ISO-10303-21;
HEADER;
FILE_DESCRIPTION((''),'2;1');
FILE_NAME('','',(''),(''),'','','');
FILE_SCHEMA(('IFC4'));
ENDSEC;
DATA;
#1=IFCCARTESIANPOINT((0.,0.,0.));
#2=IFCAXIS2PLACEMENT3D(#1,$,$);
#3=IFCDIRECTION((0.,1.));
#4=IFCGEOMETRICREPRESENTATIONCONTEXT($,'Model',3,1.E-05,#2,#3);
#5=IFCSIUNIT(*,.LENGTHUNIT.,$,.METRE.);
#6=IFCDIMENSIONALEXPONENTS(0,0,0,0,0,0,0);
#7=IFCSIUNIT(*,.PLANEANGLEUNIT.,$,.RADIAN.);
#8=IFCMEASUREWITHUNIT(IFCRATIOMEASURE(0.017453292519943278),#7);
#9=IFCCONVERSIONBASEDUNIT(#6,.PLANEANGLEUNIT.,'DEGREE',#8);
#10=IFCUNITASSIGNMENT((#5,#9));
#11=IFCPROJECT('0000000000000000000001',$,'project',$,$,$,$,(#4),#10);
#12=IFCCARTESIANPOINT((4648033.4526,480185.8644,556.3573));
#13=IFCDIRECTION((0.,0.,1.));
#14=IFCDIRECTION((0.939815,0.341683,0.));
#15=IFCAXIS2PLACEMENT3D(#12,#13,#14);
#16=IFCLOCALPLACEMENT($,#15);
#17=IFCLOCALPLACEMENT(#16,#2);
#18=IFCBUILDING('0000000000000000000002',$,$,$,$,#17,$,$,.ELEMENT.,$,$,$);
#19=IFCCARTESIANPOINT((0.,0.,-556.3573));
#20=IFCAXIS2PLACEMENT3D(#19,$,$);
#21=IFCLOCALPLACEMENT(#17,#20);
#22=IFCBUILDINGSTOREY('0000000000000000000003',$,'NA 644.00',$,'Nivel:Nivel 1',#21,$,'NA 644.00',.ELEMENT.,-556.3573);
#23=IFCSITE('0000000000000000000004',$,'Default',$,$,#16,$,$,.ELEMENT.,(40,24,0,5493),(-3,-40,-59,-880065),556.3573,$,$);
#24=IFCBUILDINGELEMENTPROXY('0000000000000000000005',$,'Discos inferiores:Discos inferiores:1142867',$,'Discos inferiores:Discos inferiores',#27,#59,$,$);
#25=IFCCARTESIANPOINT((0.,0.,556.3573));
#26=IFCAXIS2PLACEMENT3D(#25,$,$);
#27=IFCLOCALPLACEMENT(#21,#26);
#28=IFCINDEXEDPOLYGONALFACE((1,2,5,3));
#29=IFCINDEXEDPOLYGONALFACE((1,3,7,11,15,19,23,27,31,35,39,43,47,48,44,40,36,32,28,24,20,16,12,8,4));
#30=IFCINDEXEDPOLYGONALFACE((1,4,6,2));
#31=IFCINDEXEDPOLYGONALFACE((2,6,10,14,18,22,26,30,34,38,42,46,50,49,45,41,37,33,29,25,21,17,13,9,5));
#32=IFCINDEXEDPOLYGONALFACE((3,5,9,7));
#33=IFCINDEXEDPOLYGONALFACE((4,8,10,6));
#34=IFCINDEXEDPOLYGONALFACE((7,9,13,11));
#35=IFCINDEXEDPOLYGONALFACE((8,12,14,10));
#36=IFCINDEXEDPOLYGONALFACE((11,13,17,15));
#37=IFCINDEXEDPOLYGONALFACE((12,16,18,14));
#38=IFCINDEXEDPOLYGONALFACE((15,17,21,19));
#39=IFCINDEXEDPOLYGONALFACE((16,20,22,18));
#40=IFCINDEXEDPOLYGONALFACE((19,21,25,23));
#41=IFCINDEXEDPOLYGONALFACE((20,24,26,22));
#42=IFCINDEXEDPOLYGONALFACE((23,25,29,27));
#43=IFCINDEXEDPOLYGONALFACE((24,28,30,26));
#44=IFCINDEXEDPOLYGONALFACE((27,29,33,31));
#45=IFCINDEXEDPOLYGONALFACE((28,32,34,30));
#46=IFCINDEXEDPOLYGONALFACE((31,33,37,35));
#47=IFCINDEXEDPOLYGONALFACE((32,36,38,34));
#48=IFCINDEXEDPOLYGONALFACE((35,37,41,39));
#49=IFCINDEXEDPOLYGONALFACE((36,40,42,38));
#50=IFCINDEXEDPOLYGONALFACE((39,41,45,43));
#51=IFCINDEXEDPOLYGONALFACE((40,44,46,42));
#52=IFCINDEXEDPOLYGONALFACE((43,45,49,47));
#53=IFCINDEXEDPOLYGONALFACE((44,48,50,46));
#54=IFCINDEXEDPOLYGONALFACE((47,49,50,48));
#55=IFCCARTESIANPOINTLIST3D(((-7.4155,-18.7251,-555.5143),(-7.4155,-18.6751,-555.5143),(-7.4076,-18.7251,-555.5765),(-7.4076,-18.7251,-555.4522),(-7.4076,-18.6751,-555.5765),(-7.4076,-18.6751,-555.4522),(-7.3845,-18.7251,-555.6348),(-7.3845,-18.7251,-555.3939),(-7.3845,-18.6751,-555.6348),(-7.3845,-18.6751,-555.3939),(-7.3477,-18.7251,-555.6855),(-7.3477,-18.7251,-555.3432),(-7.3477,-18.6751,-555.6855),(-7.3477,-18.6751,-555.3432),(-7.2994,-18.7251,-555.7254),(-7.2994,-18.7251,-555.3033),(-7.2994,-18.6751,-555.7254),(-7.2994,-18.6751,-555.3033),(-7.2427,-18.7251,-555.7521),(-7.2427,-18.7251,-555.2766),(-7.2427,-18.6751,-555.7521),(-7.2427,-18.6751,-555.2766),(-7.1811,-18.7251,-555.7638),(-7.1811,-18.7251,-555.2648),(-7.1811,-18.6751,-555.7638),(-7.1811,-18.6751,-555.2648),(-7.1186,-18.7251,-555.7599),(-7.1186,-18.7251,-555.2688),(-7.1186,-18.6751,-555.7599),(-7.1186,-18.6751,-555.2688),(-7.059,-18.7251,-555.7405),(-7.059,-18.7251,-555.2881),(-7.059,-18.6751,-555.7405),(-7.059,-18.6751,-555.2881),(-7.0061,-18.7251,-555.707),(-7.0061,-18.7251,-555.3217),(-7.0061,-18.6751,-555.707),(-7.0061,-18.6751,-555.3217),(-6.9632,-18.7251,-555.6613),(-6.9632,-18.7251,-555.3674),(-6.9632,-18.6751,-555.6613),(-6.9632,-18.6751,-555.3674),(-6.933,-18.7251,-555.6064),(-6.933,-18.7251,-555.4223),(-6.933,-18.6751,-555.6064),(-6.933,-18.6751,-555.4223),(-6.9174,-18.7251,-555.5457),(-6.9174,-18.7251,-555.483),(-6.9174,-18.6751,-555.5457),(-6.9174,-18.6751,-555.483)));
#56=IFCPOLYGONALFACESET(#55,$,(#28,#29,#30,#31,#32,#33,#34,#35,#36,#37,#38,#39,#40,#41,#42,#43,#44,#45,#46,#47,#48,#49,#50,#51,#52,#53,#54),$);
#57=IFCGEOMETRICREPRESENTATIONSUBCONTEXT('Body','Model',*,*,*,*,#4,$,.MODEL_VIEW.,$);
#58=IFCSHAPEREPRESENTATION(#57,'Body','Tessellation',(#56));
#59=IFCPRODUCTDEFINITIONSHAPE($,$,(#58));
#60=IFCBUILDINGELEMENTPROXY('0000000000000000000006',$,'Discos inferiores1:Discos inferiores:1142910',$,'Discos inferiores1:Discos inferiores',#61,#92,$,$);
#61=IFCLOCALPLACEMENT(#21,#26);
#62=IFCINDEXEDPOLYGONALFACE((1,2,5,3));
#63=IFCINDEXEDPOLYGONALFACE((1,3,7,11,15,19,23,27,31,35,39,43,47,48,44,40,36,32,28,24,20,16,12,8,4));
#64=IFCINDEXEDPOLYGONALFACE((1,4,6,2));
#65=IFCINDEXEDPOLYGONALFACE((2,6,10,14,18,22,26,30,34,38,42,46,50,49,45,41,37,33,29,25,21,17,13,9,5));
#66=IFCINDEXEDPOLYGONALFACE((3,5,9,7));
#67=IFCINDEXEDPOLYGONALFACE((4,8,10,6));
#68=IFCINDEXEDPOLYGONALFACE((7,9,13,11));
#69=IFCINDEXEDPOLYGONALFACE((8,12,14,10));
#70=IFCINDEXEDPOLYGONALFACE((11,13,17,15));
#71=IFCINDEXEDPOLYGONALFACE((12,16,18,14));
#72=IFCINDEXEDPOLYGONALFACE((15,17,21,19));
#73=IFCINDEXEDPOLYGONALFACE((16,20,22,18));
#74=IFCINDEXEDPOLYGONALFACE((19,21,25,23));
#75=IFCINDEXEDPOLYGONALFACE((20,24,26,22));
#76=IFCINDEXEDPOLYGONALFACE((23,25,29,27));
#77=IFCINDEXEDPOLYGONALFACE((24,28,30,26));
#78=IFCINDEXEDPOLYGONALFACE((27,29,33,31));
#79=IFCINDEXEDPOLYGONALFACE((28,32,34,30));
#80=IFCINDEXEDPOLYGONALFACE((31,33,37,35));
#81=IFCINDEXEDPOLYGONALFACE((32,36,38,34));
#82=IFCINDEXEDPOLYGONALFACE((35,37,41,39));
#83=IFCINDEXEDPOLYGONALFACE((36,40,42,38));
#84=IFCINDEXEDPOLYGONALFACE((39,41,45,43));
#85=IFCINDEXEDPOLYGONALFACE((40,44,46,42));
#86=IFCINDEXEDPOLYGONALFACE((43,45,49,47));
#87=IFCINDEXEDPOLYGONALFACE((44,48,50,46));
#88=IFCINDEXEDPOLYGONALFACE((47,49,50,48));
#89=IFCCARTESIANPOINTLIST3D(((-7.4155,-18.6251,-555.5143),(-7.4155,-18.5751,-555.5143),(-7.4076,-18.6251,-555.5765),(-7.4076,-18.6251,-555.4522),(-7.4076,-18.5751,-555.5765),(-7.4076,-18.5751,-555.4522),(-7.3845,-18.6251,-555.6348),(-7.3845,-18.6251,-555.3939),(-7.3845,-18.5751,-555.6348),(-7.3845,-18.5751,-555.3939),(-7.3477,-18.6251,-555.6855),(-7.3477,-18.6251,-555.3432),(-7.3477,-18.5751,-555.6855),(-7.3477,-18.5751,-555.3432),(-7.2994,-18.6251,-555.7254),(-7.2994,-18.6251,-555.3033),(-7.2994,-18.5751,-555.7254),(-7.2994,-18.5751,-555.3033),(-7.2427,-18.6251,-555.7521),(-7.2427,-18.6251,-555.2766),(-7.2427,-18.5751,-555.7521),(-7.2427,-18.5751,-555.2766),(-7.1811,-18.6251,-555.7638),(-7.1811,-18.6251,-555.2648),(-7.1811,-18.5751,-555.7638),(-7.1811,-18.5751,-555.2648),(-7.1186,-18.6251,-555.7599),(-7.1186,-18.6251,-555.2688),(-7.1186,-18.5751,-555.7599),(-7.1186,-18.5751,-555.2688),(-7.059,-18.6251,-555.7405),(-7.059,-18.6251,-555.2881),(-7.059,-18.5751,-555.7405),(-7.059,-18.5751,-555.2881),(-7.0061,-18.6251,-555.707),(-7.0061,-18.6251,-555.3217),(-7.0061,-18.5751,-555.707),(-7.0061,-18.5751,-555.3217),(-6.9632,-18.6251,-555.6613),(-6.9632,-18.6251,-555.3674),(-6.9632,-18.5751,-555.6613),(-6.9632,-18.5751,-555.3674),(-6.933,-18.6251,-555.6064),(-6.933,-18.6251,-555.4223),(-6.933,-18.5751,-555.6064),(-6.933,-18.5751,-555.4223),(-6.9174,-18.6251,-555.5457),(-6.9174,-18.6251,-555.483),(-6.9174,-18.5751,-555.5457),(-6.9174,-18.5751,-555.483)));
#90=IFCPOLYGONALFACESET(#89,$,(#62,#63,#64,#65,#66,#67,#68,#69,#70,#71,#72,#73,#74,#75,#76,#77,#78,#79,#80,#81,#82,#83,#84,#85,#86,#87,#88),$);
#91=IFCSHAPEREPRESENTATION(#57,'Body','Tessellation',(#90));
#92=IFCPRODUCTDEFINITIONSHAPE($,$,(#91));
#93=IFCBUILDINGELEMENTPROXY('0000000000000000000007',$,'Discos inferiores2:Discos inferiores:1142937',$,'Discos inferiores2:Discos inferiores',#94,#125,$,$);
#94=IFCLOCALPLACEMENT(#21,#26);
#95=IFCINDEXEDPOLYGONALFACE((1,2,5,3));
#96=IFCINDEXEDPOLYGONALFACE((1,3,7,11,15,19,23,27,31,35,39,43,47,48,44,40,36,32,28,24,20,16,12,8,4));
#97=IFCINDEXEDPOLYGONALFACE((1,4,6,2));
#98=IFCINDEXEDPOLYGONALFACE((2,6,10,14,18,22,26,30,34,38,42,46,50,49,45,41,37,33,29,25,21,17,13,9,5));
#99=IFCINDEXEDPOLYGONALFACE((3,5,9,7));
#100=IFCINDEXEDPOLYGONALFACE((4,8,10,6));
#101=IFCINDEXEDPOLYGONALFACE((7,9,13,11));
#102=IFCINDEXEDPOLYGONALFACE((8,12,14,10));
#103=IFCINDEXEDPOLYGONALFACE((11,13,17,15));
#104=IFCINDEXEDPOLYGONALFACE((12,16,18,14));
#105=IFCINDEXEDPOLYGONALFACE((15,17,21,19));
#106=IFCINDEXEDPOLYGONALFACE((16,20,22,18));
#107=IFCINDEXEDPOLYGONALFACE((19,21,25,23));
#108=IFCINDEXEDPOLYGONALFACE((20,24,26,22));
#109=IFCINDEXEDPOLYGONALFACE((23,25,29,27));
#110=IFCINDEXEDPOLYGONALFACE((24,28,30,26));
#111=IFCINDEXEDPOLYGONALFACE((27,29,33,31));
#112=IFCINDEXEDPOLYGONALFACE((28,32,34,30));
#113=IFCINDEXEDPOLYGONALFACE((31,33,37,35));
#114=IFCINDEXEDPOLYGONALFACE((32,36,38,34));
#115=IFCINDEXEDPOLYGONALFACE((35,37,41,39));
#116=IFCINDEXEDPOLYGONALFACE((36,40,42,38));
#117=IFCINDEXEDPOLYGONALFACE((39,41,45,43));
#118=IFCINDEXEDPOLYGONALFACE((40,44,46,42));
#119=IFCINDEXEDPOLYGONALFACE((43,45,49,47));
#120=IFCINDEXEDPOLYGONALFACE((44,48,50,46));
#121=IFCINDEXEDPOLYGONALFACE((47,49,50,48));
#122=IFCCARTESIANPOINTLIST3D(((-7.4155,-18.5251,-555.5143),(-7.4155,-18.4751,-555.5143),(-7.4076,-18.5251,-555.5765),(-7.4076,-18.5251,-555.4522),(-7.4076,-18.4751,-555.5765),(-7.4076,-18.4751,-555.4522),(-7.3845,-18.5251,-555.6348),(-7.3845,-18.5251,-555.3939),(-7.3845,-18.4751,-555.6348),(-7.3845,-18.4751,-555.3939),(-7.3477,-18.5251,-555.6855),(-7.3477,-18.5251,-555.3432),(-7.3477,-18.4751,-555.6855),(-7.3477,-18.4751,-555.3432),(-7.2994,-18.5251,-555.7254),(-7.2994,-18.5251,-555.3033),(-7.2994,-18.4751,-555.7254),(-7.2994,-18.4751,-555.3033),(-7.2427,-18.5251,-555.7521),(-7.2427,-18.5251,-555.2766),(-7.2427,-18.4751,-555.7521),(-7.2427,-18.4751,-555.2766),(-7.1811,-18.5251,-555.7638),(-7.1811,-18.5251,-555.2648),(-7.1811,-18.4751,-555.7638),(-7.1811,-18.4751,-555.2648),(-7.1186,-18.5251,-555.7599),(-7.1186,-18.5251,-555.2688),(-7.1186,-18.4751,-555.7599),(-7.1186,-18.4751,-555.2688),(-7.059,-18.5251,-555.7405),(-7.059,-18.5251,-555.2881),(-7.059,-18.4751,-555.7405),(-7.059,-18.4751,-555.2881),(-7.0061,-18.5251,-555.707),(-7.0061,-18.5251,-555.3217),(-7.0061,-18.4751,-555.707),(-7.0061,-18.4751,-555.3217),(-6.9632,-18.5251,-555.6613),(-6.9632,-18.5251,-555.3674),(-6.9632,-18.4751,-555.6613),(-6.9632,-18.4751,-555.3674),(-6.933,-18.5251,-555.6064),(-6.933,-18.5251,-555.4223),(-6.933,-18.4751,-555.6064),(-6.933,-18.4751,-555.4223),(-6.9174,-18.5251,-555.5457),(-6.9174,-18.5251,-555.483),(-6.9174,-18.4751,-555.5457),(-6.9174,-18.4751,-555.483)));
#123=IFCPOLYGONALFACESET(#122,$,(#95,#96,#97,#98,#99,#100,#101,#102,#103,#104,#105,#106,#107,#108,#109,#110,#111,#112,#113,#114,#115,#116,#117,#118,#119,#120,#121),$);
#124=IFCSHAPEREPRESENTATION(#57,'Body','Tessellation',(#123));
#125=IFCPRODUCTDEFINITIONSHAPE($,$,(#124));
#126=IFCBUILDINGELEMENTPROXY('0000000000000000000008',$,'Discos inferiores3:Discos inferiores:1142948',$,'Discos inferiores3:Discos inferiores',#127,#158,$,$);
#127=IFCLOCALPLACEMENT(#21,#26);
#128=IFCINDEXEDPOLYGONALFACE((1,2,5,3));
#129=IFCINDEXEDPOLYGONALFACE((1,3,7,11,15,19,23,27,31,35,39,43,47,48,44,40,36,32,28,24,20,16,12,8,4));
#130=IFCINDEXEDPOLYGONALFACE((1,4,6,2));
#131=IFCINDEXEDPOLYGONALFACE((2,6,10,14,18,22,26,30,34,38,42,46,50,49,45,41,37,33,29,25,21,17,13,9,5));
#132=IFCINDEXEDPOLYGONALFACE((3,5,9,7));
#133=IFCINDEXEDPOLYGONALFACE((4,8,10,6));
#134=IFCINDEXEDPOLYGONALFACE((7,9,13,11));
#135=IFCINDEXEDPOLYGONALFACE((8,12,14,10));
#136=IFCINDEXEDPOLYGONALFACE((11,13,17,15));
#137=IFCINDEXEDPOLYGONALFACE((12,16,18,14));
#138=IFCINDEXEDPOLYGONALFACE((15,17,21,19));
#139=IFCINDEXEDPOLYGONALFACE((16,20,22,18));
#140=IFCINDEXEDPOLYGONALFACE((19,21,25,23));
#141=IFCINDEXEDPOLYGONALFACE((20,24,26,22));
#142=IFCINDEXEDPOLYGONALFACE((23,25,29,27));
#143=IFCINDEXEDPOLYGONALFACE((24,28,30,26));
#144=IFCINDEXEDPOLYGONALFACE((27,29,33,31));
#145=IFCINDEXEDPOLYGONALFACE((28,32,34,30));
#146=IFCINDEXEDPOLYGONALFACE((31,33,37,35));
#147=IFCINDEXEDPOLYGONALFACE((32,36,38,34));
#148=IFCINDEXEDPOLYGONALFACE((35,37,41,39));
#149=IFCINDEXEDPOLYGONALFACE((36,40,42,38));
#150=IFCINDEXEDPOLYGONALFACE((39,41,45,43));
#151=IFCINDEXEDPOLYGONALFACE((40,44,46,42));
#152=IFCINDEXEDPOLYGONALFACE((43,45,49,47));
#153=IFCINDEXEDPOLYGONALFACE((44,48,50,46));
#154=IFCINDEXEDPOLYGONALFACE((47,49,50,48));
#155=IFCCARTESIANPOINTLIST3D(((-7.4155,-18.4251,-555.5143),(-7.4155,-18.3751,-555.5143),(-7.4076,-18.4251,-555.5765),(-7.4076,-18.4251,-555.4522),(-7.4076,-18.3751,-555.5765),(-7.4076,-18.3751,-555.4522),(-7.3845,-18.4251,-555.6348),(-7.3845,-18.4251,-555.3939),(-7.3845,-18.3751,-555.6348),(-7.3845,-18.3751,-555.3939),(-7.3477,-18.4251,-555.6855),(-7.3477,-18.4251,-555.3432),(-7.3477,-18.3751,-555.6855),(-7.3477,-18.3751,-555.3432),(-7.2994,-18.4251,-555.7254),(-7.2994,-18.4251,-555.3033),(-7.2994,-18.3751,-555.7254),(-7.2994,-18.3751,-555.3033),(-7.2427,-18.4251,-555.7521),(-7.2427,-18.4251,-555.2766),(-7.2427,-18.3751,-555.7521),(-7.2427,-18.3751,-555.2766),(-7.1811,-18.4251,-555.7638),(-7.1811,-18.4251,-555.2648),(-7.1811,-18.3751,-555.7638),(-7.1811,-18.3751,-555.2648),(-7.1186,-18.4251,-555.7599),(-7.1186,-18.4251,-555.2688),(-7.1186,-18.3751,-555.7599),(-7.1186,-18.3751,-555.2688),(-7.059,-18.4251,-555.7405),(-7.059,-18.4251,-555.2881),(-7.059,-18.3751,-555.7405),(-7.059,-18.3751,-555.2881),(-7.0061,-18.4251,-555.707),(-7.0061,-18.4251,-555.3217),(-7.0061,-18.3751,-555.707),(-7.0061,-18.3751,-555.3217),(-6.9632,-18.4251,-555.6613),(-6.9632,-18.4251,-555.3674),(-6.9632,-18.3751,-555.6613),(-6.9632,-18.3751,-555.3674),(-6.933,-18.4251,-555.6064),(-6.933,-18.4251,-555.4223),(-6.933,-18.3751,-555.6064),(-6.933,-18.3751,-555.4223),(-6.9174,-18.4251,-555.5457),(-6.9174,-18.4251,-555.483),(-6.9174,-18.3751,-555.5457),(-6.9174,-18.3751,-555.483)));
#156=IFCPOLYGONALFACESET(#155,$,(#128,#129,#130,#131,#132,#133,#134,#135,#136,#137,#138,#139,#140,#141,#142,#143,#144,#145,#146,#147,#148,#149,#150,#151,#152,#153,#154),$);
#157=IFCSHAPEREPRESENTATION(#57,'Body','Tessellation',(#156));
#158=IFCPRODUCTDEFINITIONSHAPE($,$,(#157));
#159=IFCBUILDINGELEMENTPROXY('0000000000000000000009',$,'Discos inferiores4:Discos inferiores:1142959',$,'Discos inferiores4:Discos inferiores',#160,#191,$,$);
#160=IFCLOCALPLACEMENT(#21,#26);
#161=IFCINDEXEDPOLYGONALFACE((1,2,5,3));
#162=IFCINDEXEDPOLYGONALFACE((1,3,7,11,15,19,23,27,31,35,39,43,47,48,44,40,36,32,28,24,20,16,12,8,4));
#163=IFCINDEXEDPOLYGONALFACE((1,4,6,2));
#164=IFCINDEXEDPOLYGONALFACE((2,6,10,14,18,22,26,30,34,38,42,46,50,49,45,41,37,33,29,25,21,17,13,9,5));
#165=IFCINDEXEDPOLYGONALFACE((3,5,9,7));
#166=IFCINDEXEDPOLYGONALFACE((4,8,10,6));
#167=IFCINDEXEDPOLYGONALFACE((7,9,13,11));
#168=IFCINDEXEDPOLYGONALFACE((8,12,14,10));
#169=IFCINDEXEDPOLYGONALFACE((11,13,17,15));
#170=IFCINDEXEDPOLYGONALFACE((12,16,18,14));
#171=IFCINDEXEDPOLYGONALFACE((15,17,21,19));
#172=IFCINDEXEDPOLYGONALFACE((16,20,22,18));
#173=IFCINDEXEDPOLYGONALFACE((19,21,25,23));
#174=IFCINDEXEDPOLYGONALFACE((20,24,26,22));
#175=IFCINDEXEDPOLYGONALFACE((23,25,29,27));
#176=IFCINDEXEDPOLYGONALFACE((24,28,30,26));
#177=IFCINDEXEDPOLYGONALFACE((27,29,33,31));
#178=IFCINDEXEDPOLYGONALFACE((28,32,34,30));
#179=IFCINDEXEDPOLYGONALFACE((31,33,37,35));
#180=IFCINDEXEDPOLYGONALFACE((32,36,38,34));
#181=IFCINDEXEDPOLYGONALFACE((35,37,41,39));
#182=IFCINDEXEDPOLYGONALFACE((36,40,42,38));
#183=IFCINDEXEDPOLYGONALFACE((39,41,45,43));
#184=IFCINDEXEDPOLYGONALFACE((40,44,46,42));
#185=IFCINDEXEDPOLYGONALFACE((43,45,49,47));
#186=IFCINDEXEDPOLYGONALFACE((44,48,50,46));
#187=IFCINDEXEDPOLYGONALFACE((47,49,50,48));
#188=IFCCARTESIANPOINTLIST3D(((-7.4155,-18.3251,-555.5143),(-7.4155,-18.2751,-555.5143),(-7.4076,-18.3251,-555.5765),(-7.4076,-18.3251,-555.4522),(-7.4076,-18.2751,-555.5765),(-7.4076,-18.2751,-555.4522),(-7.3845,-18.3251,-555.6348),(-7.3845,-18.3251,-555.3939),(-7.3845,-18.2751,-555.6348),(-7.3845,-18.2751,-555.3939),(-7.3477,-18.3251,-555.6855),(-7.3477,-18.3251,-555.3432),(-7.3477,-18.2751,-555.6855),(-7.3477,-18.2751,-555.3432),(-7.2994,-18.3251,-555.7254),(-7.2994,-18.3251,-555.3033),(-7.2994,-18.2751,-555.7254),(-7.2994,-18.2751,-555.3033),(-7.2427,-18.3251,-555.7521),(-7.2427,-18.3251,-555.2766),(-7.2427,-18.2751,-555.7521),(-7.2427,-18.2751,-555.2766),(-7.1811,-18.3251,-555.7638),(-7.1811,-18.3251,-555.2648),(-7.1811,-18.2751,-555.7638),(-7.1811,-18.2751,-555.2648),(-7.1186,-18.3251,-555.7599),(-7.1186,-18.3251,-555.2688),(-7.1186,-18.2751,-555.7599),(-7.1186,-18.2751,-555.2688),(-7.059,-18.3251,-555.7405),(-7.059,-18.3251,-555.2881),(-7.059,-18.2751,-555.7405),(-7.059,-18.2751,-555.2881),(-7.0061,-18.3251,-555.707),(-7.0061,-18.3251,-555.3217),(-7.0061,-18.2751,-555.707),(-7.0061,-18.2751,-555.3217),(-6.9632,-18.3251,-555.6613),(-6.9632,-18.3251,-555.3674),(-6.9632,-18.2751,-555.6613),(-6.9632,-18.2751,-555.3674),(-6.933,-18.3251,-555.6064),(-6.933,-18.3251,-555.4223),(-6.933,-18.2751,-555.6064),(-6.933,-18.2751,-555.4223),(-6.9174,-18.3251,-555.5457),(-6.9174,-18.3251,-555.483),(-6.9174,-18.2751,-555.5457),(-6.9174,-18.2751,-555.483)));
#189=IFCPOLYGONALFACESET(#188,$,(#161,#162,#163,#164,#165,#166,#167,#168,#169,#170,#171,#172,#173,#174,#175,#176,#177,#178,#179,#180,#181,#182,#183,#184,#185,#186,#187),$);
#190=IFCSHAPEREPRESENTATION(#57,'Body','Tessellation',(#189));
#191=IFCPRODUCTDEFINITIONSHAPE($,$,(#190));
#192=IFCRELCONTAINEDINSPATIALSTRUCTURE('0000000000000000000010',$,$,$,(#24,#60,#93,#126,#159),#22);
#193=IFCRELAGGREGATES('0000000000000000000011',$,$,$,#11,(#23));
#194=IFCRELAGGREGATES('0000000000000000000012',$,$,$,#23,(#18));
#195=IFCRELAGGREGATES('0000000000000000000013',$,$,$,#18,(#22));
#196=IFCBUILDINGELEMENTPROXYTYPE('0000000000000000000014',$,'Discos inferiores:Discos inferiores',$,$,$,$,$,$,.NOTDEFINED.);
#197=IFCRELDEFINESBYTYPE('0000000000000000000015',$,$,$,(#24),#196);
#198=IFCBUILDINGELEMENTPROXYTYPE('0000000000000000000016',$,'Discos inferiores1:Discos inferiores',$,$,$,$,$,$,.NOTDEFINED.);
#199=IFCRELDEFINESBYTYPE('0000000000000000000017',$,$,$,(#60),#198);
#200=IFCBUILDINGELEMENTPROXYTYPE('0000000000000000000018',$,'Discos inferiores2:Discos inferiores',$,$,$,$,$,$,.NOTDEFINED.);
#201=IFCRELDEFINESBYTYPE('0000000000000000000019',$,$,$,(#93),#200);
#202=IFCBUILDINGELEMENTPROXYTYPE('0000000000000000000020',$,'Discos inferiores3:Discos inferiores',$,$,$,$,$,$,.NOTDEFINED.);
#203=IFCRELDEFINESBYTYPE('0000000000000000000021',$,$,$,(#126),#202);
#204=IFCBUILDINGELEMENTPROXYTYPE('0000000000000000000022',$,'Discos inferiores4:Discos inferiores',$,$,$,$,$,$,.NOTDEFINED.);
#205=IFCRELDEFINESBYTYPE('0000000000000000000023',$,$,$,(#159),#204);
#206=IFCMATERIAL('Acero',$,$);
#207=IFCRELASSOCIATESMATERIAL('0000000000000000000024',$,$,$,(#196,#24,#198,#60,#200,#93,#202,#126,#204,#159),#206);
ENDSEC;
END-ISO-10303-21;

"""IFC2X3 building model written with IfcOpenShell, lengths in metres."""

from ifc_helpers import new_model, entity, si_unit, converted_unit, direction, frame, origin, origin_2d_with_axis, place, context, subcontext, project, spatial, circle, extrude, source, transform, mapped, material, type_object, type_shapes, element, save


model = new_model("IFC2X3")

# Units and contexts
model_context = context("Model", 3, precision=1e-05, world=origin(), true_north=direction((0.0, 1.0)))
body_context = subcontext(model_context, "Body", "Model", "MODEL_VIEW")
ifc_project = project(units=[si_unit("LENGTHUNIT", "METRE"), converted_unit("PLANEANGLEUNIT", "DEGREE", entity("IfcRatioMeasure", 0.017453292519943278), si_unit("PLANEANGLEUNIT", "RADIAN"), dimensions=[0, 0, 0, 0, 0, 0, 0])], contexts=[model_context])

# Site, building, storey
site_placement = place(None, frame((4648033.4526, 480185.8644, 556.3573), z_axis=(0.0, 0.0, 1.0), x_axis=(0.939815, 0.341683, 0.0)))
site = spatial("IfcSite", under=ifc_project, at=site_placement, Name="Default", CompositionType="ELEMENT", RefLatitude=(40, 24, 0, 5493), RefLongitude=(-3, -40, -59, -880065), RefElevation=556.3573)
building_placement = place(site_placement, origin())
building = spatial("IfcBuilding", under=site, at=building_placement, CompositionType="ELEMENT")
storey_placement = place(building_placement, frame((0.0, 0.0, -556.3573)))
storey = spatial("IfcBuildingStorey", under=building, at=storey_placement, Name="NA 644.00", ObjectType="Nivel:Nivel 1", LongName="NA 644.00", CompositionType="ELEMENT", Elevation=-556.3573)

# Building element proxies
ifc_material_1 = material(Name="Acero")
building_element_proxy_type_1 = type_object("IfcBuildingElementProxyType", Name="Discos inferiores:Discos inferiores", PredefinedType="NOTDEFINED", material=ifc_material_1)
shared_shape_1 = source(origin(), body_context, "Body", "SweptSolid", [
    extrude(circle(Radius=0.25, at=origin_2d_with_axis()), frame((-7.1655, -18.7251, -555.5143), z_axis=(0.0, 1.0, 0.0), x_axis=(-1.0, 0.0, 0.0)), (0.0, 0.0, 1.0), 0.05),
])
type_shapes(building_element_proxy_type_1, [shared_shape_1])
proxy_1_placement = place(storey_placement, frame((0.0, 0.0, 556.3573)))
element("IfcBuildingElementProxy", 1, at=proxy_1_placement, inside=storey, type_object=building_element_proxy_type_1, material=ifc_material_1, Name="Discos inferiores:Discos inferiores:1142867", ObjectType="Discos inferiores:Discos inferiores", context=body_context, shape_type="MappedRepresentation", body=[
    mapped(shared_shape_1, transform((0.0, 0.0, 0.0), scale=1.0)),
])
building_element_proxy_type_2 = type_object("IfcBuildingElementProxyType", Name="Discos inferiores1:Discos inferiores", PredefinedType="NOTDEFINED", material=ifc_material_1)
shared_shape_2 = source(origin(), body_context, "Body", "SweptSolid", [
    extrude(circle(Radius=0.25, at=origin_2d_with_axis()), frame((-7.1655, -18.6251, -555.5143), z_axis=(0.0, 1.0, 0.0), x_axis=(-1.0, 0.0, 0.0)), (0.0, 0.0, 1.0), 0.05),
])
type_shapes(building_element_proxy_type_2, [shared_shape_2])
proxy_2_placement = place(storey_placement, frame((0.0, 0.0, 556.3573)))
element("IfcBuildingElementProxy", 2, at=proxy_2_placement, inside=storey, type_object=building_element_proxy_type_2, material=ifc_material_1, Name="Discos inferiores1:Discos inferiores:1142910", ObjectType="Discos inferiores1:Discos inferiores", context=body_context, shape_type="MappedRepresentation", body=[
    mapped(shared_shape_2, transform((0.0, 0.0, 0.0), scale=1.0)),
])
building_element_proxy_type_3 = type_object("IfcBuildingElementProxyType", Name="Discos inferiores2:Discos inferiores", PredefinedType="NOTDEFINED", material=ifc_material_1)
shared_shape_3 = source(origin(), body_context, "Body", "SweptSolid", [
    extrude(circle(Radius=0.25, at=origin_2d_with_axis()), frame((-7.1655, -18.5251, -555.5143), z_axis=(0.0, 1.0, 0.0), x_axis=(-1.0, 0.0, 0.0)), (0.0, 0.0, 1.0), 0.05),
])
type_shapes(building_element_proxy_type_3, [shared_shape_3])
proxy_3_placement = place(storey_placement, frame((0.0, 0.0, 556.3573)))
element("IfcBuildingElementProxy", 3, at=proxy_3_placement, inside=storey, type_object=building_element_proxy_type_3, material=ifc_material_1, Name="Discos inferiores2:Discos inferiores:1142937", ObjectType="Discos inferiores2:Discos inferiores", context=body_context, shape_type="MappedRepresentation", body=[
    mapped(shared_shape_3, transform((0.0, 0.0, 0.0), scale=1.0)),
])
building_element_proxy_type_4 = type_object("IfcBuildingElementProxyType", Name="Discos inferiores3:Discos inferiores", PredefinedType="NOTDEFINED", material=ifc_material_1)
shared_shape_4 = source(origin(), body_context, "Body", "SweptSolid", [
    extrude(circle(Radius=0.25, at=origin_2d_with_axis()), frame((-7.1655, -18.4251, -555.5143), z_axis=(0.0, 1.0, 0.0), x_axis=(-1.0, 0.0, 0.0)), (0.0, 0.0, 1.0), 0.05),
])
type_shapes(building_element_proxy_type_4, [shared_shape_4])
proxy_4_placement = place(storey_placement, frame((0.0, 0.0, 556.3573)))
element("IfcBuildingElementProxy", 4, at=proxy_4_placement, inside=storey, type_object=building_element_proxy_type_4, material=ifc_material_1, Name="Discos inferiores3:Discos inferiores:1142948", ObjectType="Discos inferiores3:Discos inferiores", context=body_context, shape_type="MappedRepresentation", body=[
    mapped(shared_shape_4, transform((0.0, 0.0, 0.0), scale=1.0)),
])
building_element_proxy_type_5 = type_object("IfcBuildingElementProxyType", Name="Discos inferiores4:Discos inferiores", PredefinedType="NOTDEFINED", material=ifc_material_1)
shared_shape_5 = source(origin(), body_context, "Body", "SweptSolid", [
    extrude(circle(Radius=0.25, at=origin_2d_with_axis()), frame((-7.1655, -18.3251, -555.5143), z_axis=(0.0, 1.0, 0.0), x_axis=(-1.0, 0.0, 0.0)), (0.0, 0.0, 1.0), 0.05),
])
type_shapes(building_element_proxy_type_5, [shared_shape_5])
proxy_5_placement = place(storey_placement, frame((0.0, 0.0, 556.3573)))
element("IfcBuildingElementProxy", 5, at=proxy_5_placement, inside=storey, type_object=building_element_proxy_type_5, material=ifc_material_1, Name="Discos inferiores4:Discos inferiores:1142959", ObjectType="Discos inferiores4:Discos inferiores", context=body_context, shape_type="MappedRepresentation", body=[
    mapped(shared_shape_5, transform((0.0, 0.0, 0.0), scale=1.0)),
])

save(model, "model.ifc")
